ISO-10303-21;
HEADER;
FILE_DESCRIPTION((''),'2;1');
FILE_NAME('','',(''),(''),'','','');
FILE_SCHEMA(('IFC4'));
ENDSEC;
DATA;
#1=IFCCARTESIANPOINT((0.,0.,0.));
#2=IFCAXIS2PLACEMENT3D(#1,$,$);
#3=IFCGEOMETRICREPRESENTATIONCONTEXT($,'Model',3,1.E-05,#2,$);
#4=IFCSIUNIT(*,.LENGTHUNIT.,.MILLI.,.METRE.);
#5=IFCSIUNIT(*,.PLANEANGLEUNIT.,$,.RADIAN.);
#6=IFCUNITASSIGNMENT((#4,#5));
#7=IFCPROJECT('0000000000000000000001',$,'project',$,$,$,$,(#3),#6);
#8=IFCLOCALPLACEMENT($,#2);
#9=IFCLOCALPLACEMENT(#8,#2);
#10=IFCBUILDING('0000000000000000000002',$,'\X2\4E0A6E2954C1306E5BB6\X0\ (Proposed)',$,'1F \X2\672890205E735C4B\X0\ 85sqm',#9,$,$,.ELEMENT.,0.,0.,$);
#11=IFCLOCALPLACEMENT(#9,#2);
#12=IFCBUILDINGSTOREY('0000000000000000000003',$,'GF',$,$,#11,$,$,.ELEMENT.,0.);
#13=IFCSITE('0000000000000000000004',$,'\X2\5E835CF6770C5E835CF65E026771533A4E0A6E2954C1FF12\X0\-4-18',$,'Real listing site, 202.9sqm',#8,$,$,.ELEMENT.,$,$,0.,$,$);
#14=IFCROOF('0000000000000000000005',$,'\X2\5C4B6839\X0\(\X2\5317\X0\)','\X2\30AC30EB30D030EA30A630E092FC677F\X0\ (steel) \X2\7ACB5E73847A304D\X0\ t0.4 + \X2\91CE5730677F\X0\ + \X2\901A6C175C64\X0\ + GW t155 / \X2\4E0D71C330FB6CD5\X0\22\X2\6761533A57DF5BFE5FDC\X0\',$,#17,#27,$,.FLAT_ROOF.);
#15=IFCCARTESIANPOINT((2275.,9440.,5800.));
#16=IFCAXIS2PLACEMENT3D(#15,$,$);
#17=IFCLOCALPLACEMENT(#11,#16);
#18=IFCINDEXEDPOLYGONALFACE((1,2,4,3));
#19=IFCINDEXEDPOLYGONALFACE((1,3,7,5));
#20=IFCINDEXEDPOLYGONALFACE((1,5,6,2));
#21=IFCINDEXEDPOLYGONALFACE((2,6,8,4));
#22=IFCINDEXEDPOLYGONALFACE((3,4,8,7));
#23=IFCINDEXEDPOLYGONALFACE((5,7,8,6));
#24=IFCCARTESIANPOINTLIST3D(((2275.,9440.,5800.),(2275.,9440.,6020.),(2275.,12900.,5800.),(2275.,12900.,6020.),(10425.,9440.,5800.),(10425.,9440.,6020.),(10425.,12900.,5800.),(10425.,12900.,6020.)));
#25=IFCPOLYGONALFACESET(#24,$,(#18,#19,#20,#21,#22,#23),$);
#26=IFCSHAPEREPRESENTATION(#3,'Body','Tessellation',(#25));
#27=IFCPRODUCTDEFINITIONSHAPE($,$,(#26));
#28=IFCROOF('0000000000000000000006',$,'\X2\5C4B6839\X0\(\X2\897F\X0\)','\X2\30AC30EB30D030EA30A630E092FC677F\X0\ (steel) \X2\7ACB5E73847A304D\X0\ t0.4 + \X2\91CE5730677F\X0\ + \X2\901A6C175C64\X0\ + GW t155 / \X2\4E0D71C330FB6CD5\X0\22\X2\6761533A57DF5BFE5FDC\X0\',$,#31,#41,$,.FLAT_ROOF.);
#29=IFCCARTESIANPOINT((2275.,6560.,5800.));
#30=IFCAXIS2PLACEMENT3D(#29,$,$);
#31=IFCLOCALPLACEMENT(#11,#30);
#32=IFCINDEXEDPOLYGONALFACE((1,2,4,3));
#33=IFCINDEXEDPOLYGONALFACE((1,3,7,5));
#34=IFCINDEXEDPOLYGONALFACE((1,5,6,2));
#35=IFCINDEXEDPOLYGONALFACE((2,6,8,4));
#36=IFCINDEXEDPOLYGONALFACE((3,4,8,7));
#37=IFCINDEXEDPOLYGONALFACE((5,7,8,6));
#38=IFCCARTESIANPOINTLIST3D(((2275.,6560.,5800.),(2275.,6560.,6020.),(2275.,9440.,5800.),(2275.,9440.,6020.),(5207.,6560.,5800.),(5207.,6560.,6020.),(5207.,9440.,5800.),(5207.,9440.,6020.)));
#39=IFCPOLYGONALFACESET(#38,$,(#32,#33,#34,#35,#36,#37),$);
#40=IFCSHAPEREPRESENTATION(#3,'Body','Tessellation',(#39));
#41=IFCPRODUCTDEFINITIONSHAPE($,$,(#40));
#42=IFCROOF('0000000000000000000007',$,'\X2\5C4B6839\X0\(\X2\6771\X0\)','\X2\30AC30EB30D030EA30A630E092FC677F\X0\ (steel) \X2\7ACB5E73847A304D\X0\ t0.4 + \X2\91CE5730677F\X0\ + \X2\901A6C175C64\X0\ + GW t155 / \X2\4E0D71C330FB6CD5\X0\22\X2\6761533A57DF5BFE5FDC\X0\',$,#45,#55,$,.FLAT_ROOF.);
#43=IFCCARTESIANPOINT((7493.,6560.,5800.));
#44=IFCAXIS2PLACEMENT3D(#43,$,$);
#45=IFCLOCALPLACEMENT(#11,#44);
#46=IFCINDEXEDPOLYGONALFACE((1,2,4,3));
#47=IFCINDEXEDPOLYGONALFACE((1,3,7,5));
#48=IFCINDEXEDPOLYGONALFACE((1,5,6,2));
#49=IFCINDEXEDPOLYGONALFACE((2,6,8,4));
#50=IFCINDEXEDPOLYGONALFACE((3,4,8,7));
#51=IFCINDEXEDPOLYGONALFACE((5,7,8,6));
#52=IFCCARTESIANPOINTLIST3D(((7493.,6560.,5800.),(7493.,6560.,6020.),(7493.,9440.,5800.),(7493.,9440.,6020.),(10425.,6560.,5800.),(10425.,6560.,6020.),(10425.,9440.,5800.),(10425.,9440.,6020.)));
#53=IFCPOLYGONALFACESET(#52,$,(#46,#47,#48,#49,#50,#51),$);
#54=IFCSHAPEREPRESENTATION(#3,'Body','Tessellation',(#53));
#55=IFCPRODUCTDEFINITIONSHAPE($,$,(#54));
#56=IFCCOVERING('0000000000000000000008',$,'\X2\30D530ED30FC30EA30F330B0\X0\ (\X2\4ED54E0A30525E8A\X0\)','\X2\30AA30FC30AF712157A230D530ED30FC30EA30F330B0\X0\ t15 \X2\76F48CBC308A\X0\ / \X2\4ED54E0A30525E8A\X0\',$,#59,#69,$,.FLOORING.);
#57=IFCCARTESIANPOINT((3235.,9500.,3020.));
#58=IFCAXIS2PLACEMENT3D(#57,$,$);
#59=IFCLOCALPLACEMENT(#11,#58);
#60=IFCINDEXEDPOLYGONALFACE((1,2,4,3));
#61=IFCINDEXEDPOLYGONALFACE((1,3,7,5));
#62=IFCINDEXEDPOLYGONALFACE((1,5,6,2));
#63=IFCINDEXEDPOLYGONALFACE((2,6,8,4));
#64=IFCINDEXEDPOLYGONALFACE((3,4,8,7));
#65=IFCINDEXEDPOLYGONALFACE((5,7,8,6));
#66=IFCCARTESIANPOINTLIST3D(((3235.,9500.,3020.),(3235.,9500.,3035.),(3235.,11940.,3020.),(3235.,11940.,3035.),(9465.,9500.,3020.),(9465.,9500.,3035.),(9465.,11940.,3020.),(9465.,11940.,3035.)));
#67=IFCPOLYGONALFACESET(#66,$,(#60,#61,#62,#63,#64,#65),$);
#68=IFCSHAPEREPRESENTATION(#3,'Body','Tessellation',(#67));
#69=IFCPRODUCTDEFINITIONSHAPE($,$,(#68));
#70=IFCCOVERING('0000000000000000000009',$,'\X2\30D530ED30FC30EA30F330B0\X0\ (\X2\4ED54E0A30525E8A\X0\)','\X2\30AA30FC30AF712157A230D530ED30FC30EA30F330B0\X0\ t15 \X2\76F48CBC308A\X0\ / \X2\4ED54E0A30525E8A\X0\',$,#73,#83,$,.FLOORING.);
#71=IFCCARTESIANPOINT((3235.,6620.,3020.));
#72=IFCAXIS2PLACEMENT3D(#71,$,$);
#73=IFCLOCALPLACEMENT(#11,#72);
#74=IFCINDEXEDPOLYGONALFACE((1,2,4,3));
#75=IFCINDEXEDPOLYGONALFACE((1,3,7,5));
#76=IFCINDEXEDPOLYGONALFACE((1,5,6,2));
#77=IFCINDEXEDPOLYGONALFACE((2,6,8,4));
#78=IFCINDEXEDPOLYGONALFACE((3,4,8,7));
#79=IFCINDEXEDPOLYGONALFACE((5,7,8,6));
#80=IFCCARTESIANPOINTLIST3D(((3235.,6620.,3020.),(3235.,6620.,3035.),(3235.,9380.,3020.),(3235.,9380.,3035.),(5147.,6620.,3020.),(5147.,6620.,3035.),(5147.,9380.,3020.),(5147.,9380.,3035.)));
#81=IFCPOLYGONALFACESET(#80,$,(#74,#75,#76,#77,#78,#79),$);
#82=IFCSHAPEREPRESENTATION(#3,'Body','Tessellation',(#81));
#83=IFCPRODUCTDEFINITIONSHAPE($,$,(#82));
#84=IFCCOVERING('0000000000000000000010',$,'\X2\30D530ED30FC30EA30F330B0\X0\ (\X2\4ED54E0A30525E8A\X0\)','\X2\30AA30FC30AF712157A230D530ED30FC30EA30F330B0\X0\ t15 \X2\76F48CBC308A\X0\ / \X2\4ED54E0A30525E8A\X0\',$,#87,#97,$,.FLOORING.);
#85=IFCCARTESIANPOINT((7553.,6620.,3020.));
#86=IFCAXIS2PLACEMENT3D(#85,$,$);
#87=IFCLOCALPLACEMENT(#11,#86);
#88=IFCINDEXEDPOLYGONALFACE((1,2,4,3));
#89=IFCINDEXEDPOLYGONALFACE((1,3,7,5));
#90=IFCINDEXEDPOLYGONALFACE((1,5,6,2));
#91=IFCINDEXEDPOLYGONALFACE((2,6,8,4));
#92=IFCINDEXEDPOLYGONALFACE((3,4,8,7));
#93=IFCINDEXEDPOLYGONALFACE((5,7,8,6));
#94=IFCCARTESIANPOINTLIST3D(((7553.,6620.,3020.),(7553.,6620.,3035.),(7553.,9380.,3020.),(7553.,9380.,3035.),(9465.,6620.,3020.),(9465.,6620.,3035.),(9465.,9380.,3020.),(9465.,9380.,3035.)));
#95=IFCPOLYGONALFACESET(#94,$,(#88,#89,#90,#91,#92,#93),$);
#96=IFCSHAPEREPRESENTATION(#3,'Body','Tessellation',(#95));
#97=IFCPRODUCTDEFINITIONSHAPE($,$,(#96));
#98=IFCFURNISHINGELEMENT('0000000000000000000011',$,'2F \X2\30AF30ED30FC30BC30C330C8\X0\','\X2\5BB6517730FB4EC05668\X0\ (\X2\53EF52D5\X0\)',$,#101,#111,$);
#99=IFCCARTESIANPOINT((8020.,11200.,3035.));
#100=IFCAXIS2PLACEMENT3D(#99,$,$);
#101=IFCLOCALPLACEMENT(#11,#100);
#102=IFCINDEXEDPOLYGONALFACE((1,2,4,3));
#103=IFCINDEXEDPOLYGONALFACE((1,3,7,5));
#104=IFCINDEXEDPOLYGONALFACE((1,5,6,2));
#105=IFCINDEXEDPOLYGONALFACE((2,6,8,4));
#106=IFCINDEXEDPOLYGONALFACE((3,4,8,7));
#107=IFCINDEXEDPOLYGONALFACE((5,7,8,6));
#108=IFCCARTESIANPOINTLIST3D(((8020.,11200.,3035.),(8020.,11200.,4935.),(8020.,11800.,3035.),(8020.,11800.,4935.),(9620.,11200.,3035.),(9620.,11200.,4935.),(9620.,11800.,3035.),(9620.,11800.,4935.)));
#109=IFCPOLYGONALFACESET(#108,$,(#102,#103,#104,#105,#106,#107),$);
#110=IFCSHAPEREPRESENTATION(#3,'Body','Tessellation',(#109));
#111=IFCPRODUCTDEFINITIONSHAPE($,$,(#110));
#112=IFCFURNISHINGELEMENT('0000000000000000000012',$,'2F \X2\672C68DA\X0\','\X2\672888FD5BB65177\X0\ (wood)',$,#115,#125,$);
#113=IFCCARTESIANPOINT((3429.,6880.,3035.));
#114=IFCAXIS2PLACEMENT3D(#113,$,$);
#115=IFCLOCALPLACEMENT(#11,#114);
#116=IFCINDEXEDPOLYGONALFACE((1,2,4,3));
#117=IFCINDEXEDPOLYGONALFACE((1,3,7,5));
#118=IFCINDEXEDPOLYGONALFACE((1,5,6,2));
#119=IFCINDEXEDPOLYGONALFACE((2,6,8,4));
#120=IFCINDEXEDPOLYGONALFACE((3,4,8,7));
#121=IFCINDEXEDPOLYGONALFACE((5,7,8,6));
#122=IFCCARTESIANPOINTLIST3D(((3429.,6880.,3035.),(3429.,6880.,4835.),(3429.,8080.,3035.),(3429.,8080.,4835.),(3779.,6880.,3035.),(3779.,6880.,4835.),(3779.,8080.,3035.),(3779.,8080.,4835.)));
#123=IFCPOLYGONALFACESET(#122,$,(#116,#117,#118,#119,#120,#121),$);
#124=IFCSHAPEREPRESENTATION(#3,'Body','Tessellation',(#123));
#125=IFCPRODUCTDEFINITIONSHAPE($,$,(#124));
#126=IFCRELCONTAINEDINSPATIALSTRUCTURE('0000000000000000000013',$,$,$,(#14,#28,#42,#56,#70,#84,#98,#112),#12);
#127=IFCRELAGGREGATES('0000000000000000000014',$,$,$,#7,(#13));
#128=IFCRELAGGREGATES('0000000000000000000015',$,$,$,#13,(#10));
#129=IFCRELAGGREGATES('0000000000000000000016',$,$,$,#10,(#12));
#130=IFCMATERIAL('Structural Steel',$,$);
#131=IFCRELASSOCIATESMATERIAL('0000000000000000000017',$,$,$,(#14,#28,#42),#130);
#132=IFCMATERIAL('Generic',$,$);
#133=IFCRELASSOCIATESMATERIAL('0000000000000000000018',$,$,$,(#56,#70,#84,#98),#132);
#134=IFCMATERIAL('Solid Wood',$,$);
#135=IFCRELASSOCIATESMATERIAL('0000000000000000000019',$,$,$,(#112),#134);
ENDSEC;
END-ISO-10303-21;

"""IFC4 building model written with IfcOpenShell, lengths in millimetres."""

from ifc_helpers import new_model, si_unit, frame, frame_2d, origin, place, context, project, spatial, rectangle, extrude, material, element, save


model = new_model("IFC4")

# Units and contexts
model_context = context("Model", 3, precision=1e-05, world=origin())
ifc_project = project(units=[si_unit("LENGTHUNIT", "METRE", prefix="MILLI"), si_unit("PLANEANGLEUNIT", "RADIAN")], contexts=[model_context])

# Site, building, storey
site_placement = place(None, origin())
site = spatial("IfcSite", under=ifc_project, at=site_placement, Name="広島県広島市東区上温品２-4-18", ObjectType="Real listing site, 202.9sqm", CompositionType="ELEMENT", RefElevation=0.0)
building_placement = place(site_placement, origin())
building = spatial("IfcBuilding", under=site, at=building_placement, Name="上温品の家 (Proposed)", ObjectType="1F 木造平屋 85sqm", CompositionType="ELEMENT", ElevationOfRefHeight=0.0, ElevationOfTerrain=0.0)
storey_placement = place(building_placement, origin())
storey = spatial("IfcBuildingStorey", under=building, at=storey_placement, Name="GF", CompositionType="ELEMENT", Elevation=0.0)

# Shared definitions
ifc_material_1 = material(Name="Solid Wood")

# Shared definitions
ifc_material_2 = material(Name="Generic")

# Roofs
ifc_material_3 = material(Name="Structural Steel")
for number, where, name in (
    (1, (2275.0, 9440.0, 5800.0), "屋根(北)"),
):
    element("IfcRoof", number, at=place(storey_placement, frame(where)), inside=storey, material=ifc_material_3, Name=name, Description="ガルバリウム鋼板 (steel) 立平葺き t0.4 + 野地板 + 通気層 + GW t155 / 不燃・法22条区域対応", PredefinedType="FLAT_ROOF", context=model_context, shape_type="SweptSolid", body=[
        extrude(rectangle(XDim=8150.0, YDim=3460.0, at=frame_2d((4075.0, 1730.0))), frame((2275.0, 9440.0, 5800.0)), (0.0, 0.0, 1.0), 220.0),
    ])
roof_1_placement = place(storey_placement, frame((2275.0, 6560.0, 5800.0)))
element("IfcRoof", 2, at=roof_1_placement, inside=storey, material=ifc_material_3, Name="屋根(西)", Description="ガルバリウム鋼板 (steel) 立平葺き t0.4 + 野地板 + 通気層 + GW t155 / 不燃・法22条区域対応", PredefinedType="FLAT_ROOF", context=model_context, shape_type="SweptSolid", body=[
    extrude(rectangle(XDim=2932.0, YDim=2880.0, at=frame_2d((1466.0, 1440.0))), frame((2275.0, 6560.0, 5800.0)), (0.0, 0.0, 1.0), 220.0),
])
roof_2_placement = place(storey_placement, frame((7493.0, 6560.0, 5800.0)))
element("IfcRoof", 3, at=roof_2_placement, inside=storey, material=ifc_material_3, Name="屋根(東)", Description="ガルバリウム鋼板 (steel) 立平葺き t0.4 + 野地板 + 通気層 + GW t155 / 不燃・法22条区域対応", PredefinedType="FLAT_ROOF", context=model_context, shape_type="SweptSolid", body=[
    extrude(rectangle(XDim=2932.0, YDim=2880.0, at=frame_2d((1466.0, 1440.0))), frame((7493.0, 6560.0, 5800.0)), (0.0, 0.0, 1.0), 220.0),
])

# Coverings
covering_1_placement = place(storey_placement, frame((3235.0, 9500.0, 3020.0)))
element("IfcCovering", 4, at=covering_1_placement, inside=storey, material=ifc_material_2, Name="フローリング (仕上げ床)", Description="オーク無垢フローリング t15 直貼り / 仕上げ床", PredefinedType="FLOORING", context=model_context, shape_type="SweptSolid", body=[
    extrude(rectangle(XDim=6230.0, YDim=2440.0, at=frame_2d((3115.0, 1220.0))), frame((3235.0, 9500.0, 3020.0)), (0.0, 0.0, 1.0), 15.0),
])
covering_2_placement = place(storey_placement, frame((3235.0, 6620.0, 3020.0)))
element("IfcCovering", 5, at=covering_2_placement, inside=storey, material=ifc_material_2, Name="フローリング (仕上げ床)", Description="オーク無垢フローリング t15 直貼り / 仕上げ床", PredefinedType="FLOORING", context=model_context, shape_type="SweptSolid", body=[
    extrude(rectangle(XDim=1912.0, YDim=2760.0, at=frame_2d((956.0, 1380.0))), frame((3235.0, 6620.0, 3020.0)), (0.0, 0.0, 1.0), 15.0),
])
covering_3_placement = place(storey_placement, frame((7553.0, 6620.0, 3020.0)))
element("IfcCovering", 6, at=covering_3_placement, inside=storey, material=ifc_material_2, Name="フローリング (仕上げ床)", Description="オーク無垢フローリング t15 直貼り / 仕上げ床", PredefinedType="FLOORING", context=model_context, shape_type="SweptSolid", body=[
    extrude(rectangle(XDim=1912.0, YDim=2760.0, at=frame_2d((956.0, 1380.0))), frame((7553.0, 6620.0, 3020.0)), (0.0, 0.0, 1.0), 15.0),
])

# Furnishing elements
furnishing_1_placement = place(storey_placement, frame((8020.0, 11200.0, 3035.0)))
element("IfcFurnishingElement", 7, at=furnishing_1_placement, inside=storey, material=ifc_material_2, Name="2F クローゼット", Description="家具・什器 (可動)", context=model_context, shape_type="SweptSolid", body=[
    extrude(rectangle(XDim=1600.0, YDim=600.0, at=frame_2d((800.0, 300.0))), frame((8020.0, 11200.0, 3035.0)), (0.0, 0.0, 1.0), 1900.0),
])
furnishing_2_placement = place(storey_placement, frame((3429.0, 6880.0, 3035.0)))
element("IfcFurnishingElement", 8, at=furnishing_2_placement, inside=storey, material=ifc_material_1, Name="2F 本棚", Description="木製家具 (wood)", context=model_context, shape_type="SweptSolid", body=[
    extrude(rectangle(XDim=350.0, YDim=1200.0, at=frame_2d((175.0, 600.0))), frame((3429.0, 6880.0, 3035.0)), (0.0, 0.0, 1.0), 1800.0),
])

save(model, "model.ifc")
